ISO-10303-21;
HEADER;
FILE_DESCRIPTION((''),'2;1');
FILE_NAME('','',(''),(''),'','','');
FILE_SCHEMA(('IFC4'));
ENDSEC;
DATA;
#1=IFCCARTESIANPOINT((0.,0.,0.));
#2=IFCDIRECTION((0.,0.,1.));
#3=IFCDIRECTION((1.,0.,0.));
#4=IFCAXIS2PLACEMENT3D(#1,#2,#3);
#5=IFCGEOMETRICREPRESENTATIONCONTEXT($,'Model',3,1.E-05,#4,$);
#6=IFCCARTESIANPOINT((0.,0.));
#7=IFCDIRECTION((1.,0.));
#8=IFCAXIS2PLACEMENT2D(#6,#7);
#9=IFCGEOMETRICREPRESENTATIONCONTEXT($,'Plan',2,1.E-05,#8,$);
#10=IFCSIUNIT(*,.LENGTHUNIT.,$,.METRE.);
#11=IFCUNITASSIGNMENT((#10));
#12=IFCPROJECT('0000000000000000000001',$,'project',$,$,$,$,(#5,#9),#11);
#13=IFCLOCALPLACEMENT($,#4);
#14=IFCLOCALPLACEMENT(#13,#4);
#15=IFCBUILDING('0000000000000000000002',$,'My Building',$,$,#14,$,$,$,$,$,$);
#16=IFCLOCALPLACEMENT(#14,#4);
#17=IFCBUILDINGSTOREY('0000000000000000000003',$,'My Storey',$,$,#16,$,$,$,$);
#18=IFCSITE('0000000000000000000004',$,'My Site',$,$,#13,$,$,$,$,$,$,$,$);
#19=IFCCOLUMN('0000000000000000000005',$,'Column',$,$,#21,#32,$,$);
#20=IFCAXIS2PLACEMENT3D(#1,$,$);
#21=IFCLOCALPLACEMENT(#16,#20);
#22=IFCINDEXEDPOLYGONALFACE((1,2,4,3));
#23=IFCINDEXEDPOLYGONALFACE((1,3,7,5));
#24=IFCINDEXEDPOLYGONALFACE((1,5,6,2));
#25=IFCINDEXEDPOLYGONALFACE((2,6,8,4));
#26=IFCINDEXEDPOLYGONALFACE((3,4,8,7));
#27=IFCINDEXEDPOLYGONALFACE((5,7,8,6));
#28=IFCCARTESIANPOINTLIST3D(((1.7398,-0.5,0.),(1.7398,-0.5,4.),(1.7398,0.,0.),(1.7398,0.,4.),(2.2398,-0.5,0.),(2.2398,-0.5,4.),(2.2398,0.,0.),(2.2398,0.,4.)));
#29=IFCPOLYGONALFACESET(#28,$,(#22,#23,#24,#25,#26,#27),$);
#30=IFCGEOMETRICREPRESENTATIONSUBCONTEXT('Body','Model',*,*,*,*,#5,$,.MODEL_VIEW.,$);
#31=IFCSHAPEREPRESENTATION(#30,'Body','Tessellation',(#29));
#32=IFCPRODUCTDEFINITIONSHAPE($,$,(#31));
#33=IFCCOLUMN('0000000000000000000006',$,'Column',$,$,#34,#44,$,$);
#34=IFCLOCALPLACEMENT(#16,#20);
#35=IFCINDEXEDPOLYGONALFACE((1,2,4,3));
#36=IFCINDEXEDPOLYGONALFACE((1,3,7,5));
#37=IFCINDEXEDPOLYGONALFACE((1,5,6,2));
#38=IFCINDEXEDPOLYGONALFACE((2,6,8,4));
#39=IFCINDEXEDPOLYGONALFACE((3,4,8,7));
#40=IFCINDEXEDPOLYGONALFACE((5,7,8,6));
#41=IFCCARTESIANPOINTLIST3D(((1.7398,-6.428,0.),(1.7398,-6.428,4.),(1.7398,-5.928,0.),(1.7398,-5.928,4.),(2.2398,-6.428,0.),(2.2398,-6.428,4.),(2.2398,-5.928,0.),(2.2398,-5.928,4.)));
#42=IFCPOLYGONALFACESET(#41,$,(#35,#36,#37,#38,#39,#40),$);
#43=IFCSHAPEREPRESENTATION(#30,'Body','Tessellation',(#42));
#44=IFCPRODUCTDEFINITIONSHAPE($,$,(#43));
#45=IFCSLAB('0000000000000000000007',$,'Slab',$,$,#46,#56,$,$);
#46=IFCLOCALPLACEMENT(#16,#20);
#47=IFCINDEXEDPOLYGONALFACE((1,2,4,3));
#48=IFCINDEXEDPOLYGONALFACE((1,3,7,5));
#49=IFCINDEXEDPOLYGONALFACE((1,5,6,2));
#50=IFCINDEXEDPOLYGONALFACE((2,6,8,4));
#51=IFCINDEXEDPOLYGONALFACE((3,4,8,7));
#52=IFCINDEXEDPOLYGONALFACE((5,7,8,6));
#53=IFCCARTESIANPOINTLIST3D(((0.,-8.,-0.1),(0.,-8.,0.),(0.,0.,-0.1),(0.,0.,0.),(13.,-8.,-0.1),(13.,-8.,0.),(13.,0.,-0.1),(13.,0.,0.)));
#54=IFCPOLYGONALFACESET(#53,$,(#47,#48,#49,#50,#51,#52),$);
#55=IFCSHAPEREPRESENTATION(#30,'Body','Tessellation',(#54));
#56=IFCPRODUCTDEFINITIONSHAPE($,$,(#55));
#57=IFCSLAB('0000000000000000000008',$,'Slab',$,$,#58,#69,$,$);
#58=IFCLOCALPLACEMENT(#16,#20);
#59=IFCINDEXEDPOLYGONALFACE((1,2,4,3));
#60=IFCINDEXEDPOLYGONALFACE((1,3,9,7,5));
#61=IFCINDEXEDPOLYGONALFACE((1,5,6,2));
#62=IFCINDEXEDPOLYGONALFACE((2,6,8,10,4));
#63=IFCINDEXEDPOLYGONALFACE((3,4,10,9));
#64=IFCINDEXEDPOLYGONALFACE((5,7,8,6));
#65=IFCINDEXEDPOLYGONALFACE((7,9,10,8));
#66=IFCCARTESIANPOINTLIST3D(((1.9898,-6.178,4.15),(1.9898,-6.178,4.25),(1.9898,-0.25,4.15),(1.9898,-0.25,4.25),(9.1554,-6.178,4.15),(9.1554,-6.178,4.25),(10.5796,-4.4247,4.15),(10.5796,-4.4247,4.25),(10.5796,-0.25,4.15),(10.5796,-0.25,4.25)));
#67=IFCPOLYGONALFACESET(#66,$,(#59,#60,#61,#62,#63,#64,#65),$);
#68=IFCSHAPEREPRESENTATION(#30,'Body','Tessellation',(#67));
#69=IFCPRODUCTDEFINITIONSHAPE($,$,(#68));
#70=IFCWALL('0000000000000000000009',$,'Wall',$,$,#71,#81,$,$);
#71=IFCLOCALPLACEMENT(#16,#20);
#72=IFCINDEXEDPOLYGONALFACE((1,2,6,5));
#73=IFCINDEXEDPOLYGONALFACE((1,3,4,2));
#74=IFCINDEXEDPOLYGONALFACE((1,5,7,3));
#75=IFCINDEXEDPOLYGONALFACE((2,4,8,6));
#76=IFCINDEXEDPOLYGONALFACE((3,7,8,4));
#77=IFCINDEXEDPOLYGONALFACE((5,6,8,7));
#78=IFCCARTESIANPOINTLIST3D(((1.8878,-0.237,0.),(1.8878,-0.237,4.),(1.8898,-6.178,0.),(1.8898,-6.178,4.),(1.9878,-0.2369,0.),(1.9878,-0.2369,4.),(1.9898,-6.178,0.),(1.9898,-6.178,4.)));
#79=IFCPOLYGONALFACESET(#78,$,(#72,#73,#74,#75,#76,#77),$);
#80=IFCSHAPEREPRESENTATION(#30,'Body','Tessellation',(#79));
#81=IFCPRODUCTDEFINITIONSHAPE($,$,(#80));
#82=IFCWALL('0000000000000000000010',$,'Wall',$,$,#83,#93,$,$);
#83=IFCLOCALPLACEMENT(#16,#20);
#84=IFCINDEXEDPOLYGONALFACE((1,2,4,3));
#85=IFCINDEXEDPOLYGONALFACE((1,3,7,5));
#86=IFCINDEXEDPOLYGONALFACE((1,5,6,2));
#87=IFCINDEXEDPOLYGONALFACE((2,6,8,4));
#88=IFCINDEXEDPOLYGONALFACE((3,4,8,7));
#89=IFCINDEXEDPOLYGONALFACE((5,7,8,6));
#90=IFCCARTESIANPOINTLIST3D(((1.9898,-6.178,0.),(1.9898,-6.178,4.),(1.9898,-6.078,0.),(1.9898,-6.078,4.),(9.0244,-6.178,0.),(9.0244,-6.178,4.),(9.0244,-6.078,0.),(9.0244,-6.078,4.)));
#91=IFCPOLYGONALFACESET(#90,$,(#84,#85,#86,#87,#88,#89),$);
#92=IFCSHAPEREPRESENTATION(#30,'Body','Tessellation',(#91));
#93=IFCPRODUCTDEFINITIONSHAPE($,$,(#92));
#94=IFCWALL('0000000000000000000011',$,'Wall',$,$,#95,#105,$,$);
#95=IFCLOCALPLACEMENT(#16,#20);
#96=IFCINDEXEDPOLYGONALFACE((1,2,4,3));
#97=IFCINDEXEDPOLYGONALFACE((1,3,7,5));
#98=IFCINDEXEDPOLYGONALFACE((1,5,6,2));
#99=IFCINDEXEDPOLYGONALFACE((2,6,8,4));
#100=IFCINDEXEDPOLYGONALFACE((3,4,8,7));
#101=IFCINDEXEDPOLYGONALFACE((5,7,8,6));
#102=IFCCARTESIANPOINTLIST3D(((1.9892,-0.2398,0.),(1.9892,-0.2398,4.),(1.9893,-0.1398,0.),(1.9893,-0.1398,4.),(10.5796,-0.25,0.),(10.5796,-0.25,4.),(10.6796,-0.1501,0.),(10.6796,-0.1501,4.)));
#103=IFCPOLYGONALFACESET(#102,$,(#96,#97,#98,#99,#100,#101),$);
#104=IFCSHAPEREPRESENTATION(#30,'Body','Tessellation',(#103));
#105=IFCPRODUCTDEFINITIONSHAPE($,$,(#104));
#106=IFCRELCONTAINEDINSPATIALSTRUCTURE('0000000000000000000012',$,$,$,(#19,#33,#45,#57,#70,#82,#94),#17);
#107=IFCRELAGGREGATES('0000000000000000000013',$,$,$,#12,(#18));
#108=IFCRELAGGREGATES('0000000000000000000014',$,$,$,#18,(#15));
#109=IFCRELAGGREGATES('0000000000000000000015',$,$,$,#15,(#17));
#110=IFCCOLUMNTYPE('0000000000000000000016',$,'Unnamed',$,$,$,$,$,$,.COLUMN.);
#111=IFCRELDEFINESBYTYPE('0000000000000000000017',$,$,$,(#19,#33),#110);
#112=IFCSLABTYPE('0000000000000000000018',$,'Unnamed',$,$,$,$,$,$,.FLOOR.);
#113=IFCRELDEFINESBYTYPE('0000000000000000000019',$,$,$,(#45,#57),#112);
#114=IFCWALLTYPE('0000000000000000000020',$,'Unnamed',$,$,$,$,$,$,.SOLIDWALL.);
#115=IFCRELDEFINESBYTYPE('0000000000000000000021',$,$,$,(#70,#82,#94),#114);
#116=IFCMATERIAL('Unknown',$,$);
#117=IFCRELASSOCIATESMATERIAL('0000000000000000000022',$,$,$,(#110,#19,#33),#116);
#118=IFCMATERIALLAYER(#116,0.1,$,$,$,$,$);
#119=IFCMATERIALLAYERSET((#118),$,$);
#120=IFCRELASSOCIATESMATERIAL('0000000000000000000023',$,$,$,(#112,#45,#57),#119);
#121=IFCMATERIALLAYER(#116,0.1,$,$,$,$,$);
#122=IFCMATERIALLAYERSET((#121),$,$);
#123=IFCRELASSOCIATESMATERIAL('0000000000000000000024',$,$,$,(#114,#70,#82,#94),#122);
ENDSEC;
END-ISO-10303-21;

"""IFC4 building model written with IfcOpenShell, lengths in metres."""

from ifc_helpers import new_model, si_unit, frame, origin_with_axes, origin_2d_with_axis, place, context, subcontext, project, spatial, line, indexed_curve, rectangle, outline, extrude, material, layer, layer_set, layer_usage, material_profile, profile_set, profile_usage, type_object, element, save


model = new_model("IFC4")

# Units and contexts
model_context = context("Model", 3, precision=1e-05, world=origin_with_axes())
plan_context = context("Plan", 2, precision=1e-05, world=origin_2d_with_axis())
body_context_1 = subcontext(model_context, "Body", "Model", "MODEL_VIEW")
ifc_project = project(units=[si_unit("LENGTHUNIT", "METRE")], contexts=[model_context, plan_context])

# Site, building, storey
site_placement = place(None, origin_with_axes())
site = spatial("IfcSite", under=ifc_project, at=site_placement, Name="My Site")
building_placement = place(site_placement, origin_with_axes())
building = spatial("IfcBuilding", under=site, at=building_placement, Name="My Building")
storey_placement = place(building_placement, origin_with_axes())
storey = spatial("IfcBuildingStorey", under=building, at=storey_placement, Name="My Storey")

# Columns
ifc_material = material(Name="Unknown")
ifc_material_profile_1 = material_profile(ifc_material, rectangle(XDim=0.5, YDim=0.5))
ifc_profile_set_1 = profile_set([ifc_material_profile_1])
ifc_profile_usage_1 = profile_usage(ifc_profile_set_1, cardinal=5)
column_type = type_object("IfcColumnType", Name="Unnamed", PredefinedType="COLUMN", material=ifc_profile_set_1)
column_1_placement = place(storey_placement, frame((1.9898, -0.25, 0.0), z_axis=(0.0, 0.0, 1.0), x_axis=(1.0, 0.0, 0.0)))
element("IfcColumn", 1, at=column_1_placement, inside=storey, type_object=column_type, material=ifc_profile_usage_1, Name="Column", context=body_context_1, shape_type="SweptSolid", body=[
    extrude(rectangle(XDim=0.5, YDim=0.5), origin_with_axes(), (0.0, 0.0, 1.0), 4.0),
])
ifc_profile_usage_2 = profile_usage(ifc_profile_set_1, cardinal=5)
column_2_placement = place(storey_placement, frame((1.9898, -6.178, 0.0), z_axis=(0.0, 0.0, 1.0), x_axis=(1.0, 0.0, 0.0)))
element("IfcColumn", 2, at=column_2_placement, inside=storey, type_object=column_type, material=ifc_profile_usage_2, Name="Column", context=body_context_1, shape_type="SweptSolid", body=[
    extrude(rectangle(XDim=0.5, YDim=0.5), origin_with_axes(), (0.0, 0.0, 1.0), 4.0),
])

# Slabs
ifc_layer_1 = layer(ifc_material, 0.1)
ifc_layer_set_1 = layer_set([ifc_layer_1])
ifc_layer_usage_1 = layer_usage(ifc_layer_set_1, "AXIS3", "POSITIVE", -0.1)
slab_type = type_object("IfcSlabType", Name="Unnamed", PredefinedType="FLOOR", material=ifc_layer_set_1)
slab_1_placement = place(storey_placement, origin_with_axes())
element("IfcSlab", 3, at=slab_1_placement, inside=storey, type_object=slab_type, material=ifc_layer_usage_1, Name="Slab", context=body_context_1, shape_type="SweptSolid", body=[
    extrude(outline(indexed_curve([(0.0, 0.0), (0.0, -8.0), (13.0, -8.0), (13.0, 0.0), (0.0, 0.0)])), frame((0.0, 0.0, -0.1), z_axis=(0.0, 0.0, 1.0), x_axis=(1.0, 0.0, 0.0)), (0.0, 0.0, 1.0), 0.1),
])
ifc_layer_usage_2 = layer_usage(ifc_layer_set_1, "AXIS3", "POSITIVE", -0.1)
slab_2_placement = place(storey_placement, frame((1.9898, -0.25, 4.25), z_axis=(0.0, 0.0, 1.0), x_axis=(1.0, 0.0, 0.0)))
element("IfcSlab", 4, at=slab_2_placement, inside=storey, type_object=slab_type, material=ifc_layer_usage_2, Name="Slab", context=body_context_1, shape_type="SweptSolid", body=[
    extrude(outline(indexed_curve([(0.0, 0.0), (0.0, -5.928), (7.1656, -5.928), (8.5898, -4.1747), (8.5898, 0.0), (0.0, 0.0)])), frame((0.0, 0.0, -0.1), z_axis=(0.0, 0.0, 1.0), x_axis=(1.0, 0.0, 0.0)), (0.0, 0.0, 1.0), 0.1),
])

# Walls
ifc_layer_2 = layer(ifc_material, 0.1)
ifc_layer_set_2 = layer_set([ifc_layer_2])
ifc_layer_usage_3 = layer_usage(ifc_layer_set_2, "AXIS2", "POSITIVE", 0.0)
wall_type = type_object("IfcWallType", Name="Unnamed", PredefinedType="SOLIDWALL", material=ifc_layer_set_2)
wall_1_placement = place(storey_placement, frame((1.9898, -6.178, 0.0), z_axis=(0.0, 0.0, 1.0), x_axis=(-0.000335, 1.0, 0.0)))
element("IfcWall", 5, at=wall_1_placement, inside=storey, type_object=wall_type, material=ifc_layer_usage_3, Name="Wall", context=body_context_1, shape_type="SweptSolid", body=[
    extrude(outline(indexed_curve([(0.0, 0.0), (0.0, 0.1), (5.9411, 0.1), (5.9411, 0.0)], segments=[line(1, 2, 3, 4, 1)])), origin_with_axes(), (0.0, 0.0, 1.0), 4.0),
])
ifc_layer_usage_4 = layer_usage(ifc_layer_set_2, "AXIS2", "POSITIVE", 0.0)
wall_2_placement = place(storey_placement, frame((1.9898, -6.178, 0.0), z_axis=(0.0, 0.0, 1.0), x_axis=(1.0, 0.0, 0.0)))
element("IfcWall", 6, at=wall_2_placement, inside=storey, type_object=wall_type, material=ifc_layer_usage_4, Name="Wall", context=body_context_1, shape_type="SweptSolid", body=[
    extrude(outline(indexed_curve([(0.0, 0.0), (0.0, 0.1), (7.0347, 0.1), (7.0347, 0.0)], segments=[line(1, 2, 3, 4, 1)])), origin_with_axes(), (0.0, 0.0, 1.0), 4.0),
])
ifc_layer_usage_5 = layer_usage(ifc_layer_set_2, "AXIS2", "POSITIVE", 0.0)
wall_3_placement = place(storey_placement, frame((1.9892, -0.2398, 0.0), z_axis=(0.0, 0.0, 1.0), x_axis=(0.999999, -0.001189, 0.0)))
element("IfcWall", 7, at=wall_3_placement, inside=storey, type_object=wall_type, material=ifc_layer_usage_5, Name="Wall", context=body_context_1, shape_type="SweptSolid", body=[
    extrude(outline(indexed_curve([(0.0, 0.0), (0.0, 0.1), (8.6903, 0.1), (8.5904, 0.0)], segments=[line(1, 2, 3, 4, 1)])), origin_with_axes(), (0.0, 0.0, 1.0), 4.0),
])

save(model, "model.ifc")
